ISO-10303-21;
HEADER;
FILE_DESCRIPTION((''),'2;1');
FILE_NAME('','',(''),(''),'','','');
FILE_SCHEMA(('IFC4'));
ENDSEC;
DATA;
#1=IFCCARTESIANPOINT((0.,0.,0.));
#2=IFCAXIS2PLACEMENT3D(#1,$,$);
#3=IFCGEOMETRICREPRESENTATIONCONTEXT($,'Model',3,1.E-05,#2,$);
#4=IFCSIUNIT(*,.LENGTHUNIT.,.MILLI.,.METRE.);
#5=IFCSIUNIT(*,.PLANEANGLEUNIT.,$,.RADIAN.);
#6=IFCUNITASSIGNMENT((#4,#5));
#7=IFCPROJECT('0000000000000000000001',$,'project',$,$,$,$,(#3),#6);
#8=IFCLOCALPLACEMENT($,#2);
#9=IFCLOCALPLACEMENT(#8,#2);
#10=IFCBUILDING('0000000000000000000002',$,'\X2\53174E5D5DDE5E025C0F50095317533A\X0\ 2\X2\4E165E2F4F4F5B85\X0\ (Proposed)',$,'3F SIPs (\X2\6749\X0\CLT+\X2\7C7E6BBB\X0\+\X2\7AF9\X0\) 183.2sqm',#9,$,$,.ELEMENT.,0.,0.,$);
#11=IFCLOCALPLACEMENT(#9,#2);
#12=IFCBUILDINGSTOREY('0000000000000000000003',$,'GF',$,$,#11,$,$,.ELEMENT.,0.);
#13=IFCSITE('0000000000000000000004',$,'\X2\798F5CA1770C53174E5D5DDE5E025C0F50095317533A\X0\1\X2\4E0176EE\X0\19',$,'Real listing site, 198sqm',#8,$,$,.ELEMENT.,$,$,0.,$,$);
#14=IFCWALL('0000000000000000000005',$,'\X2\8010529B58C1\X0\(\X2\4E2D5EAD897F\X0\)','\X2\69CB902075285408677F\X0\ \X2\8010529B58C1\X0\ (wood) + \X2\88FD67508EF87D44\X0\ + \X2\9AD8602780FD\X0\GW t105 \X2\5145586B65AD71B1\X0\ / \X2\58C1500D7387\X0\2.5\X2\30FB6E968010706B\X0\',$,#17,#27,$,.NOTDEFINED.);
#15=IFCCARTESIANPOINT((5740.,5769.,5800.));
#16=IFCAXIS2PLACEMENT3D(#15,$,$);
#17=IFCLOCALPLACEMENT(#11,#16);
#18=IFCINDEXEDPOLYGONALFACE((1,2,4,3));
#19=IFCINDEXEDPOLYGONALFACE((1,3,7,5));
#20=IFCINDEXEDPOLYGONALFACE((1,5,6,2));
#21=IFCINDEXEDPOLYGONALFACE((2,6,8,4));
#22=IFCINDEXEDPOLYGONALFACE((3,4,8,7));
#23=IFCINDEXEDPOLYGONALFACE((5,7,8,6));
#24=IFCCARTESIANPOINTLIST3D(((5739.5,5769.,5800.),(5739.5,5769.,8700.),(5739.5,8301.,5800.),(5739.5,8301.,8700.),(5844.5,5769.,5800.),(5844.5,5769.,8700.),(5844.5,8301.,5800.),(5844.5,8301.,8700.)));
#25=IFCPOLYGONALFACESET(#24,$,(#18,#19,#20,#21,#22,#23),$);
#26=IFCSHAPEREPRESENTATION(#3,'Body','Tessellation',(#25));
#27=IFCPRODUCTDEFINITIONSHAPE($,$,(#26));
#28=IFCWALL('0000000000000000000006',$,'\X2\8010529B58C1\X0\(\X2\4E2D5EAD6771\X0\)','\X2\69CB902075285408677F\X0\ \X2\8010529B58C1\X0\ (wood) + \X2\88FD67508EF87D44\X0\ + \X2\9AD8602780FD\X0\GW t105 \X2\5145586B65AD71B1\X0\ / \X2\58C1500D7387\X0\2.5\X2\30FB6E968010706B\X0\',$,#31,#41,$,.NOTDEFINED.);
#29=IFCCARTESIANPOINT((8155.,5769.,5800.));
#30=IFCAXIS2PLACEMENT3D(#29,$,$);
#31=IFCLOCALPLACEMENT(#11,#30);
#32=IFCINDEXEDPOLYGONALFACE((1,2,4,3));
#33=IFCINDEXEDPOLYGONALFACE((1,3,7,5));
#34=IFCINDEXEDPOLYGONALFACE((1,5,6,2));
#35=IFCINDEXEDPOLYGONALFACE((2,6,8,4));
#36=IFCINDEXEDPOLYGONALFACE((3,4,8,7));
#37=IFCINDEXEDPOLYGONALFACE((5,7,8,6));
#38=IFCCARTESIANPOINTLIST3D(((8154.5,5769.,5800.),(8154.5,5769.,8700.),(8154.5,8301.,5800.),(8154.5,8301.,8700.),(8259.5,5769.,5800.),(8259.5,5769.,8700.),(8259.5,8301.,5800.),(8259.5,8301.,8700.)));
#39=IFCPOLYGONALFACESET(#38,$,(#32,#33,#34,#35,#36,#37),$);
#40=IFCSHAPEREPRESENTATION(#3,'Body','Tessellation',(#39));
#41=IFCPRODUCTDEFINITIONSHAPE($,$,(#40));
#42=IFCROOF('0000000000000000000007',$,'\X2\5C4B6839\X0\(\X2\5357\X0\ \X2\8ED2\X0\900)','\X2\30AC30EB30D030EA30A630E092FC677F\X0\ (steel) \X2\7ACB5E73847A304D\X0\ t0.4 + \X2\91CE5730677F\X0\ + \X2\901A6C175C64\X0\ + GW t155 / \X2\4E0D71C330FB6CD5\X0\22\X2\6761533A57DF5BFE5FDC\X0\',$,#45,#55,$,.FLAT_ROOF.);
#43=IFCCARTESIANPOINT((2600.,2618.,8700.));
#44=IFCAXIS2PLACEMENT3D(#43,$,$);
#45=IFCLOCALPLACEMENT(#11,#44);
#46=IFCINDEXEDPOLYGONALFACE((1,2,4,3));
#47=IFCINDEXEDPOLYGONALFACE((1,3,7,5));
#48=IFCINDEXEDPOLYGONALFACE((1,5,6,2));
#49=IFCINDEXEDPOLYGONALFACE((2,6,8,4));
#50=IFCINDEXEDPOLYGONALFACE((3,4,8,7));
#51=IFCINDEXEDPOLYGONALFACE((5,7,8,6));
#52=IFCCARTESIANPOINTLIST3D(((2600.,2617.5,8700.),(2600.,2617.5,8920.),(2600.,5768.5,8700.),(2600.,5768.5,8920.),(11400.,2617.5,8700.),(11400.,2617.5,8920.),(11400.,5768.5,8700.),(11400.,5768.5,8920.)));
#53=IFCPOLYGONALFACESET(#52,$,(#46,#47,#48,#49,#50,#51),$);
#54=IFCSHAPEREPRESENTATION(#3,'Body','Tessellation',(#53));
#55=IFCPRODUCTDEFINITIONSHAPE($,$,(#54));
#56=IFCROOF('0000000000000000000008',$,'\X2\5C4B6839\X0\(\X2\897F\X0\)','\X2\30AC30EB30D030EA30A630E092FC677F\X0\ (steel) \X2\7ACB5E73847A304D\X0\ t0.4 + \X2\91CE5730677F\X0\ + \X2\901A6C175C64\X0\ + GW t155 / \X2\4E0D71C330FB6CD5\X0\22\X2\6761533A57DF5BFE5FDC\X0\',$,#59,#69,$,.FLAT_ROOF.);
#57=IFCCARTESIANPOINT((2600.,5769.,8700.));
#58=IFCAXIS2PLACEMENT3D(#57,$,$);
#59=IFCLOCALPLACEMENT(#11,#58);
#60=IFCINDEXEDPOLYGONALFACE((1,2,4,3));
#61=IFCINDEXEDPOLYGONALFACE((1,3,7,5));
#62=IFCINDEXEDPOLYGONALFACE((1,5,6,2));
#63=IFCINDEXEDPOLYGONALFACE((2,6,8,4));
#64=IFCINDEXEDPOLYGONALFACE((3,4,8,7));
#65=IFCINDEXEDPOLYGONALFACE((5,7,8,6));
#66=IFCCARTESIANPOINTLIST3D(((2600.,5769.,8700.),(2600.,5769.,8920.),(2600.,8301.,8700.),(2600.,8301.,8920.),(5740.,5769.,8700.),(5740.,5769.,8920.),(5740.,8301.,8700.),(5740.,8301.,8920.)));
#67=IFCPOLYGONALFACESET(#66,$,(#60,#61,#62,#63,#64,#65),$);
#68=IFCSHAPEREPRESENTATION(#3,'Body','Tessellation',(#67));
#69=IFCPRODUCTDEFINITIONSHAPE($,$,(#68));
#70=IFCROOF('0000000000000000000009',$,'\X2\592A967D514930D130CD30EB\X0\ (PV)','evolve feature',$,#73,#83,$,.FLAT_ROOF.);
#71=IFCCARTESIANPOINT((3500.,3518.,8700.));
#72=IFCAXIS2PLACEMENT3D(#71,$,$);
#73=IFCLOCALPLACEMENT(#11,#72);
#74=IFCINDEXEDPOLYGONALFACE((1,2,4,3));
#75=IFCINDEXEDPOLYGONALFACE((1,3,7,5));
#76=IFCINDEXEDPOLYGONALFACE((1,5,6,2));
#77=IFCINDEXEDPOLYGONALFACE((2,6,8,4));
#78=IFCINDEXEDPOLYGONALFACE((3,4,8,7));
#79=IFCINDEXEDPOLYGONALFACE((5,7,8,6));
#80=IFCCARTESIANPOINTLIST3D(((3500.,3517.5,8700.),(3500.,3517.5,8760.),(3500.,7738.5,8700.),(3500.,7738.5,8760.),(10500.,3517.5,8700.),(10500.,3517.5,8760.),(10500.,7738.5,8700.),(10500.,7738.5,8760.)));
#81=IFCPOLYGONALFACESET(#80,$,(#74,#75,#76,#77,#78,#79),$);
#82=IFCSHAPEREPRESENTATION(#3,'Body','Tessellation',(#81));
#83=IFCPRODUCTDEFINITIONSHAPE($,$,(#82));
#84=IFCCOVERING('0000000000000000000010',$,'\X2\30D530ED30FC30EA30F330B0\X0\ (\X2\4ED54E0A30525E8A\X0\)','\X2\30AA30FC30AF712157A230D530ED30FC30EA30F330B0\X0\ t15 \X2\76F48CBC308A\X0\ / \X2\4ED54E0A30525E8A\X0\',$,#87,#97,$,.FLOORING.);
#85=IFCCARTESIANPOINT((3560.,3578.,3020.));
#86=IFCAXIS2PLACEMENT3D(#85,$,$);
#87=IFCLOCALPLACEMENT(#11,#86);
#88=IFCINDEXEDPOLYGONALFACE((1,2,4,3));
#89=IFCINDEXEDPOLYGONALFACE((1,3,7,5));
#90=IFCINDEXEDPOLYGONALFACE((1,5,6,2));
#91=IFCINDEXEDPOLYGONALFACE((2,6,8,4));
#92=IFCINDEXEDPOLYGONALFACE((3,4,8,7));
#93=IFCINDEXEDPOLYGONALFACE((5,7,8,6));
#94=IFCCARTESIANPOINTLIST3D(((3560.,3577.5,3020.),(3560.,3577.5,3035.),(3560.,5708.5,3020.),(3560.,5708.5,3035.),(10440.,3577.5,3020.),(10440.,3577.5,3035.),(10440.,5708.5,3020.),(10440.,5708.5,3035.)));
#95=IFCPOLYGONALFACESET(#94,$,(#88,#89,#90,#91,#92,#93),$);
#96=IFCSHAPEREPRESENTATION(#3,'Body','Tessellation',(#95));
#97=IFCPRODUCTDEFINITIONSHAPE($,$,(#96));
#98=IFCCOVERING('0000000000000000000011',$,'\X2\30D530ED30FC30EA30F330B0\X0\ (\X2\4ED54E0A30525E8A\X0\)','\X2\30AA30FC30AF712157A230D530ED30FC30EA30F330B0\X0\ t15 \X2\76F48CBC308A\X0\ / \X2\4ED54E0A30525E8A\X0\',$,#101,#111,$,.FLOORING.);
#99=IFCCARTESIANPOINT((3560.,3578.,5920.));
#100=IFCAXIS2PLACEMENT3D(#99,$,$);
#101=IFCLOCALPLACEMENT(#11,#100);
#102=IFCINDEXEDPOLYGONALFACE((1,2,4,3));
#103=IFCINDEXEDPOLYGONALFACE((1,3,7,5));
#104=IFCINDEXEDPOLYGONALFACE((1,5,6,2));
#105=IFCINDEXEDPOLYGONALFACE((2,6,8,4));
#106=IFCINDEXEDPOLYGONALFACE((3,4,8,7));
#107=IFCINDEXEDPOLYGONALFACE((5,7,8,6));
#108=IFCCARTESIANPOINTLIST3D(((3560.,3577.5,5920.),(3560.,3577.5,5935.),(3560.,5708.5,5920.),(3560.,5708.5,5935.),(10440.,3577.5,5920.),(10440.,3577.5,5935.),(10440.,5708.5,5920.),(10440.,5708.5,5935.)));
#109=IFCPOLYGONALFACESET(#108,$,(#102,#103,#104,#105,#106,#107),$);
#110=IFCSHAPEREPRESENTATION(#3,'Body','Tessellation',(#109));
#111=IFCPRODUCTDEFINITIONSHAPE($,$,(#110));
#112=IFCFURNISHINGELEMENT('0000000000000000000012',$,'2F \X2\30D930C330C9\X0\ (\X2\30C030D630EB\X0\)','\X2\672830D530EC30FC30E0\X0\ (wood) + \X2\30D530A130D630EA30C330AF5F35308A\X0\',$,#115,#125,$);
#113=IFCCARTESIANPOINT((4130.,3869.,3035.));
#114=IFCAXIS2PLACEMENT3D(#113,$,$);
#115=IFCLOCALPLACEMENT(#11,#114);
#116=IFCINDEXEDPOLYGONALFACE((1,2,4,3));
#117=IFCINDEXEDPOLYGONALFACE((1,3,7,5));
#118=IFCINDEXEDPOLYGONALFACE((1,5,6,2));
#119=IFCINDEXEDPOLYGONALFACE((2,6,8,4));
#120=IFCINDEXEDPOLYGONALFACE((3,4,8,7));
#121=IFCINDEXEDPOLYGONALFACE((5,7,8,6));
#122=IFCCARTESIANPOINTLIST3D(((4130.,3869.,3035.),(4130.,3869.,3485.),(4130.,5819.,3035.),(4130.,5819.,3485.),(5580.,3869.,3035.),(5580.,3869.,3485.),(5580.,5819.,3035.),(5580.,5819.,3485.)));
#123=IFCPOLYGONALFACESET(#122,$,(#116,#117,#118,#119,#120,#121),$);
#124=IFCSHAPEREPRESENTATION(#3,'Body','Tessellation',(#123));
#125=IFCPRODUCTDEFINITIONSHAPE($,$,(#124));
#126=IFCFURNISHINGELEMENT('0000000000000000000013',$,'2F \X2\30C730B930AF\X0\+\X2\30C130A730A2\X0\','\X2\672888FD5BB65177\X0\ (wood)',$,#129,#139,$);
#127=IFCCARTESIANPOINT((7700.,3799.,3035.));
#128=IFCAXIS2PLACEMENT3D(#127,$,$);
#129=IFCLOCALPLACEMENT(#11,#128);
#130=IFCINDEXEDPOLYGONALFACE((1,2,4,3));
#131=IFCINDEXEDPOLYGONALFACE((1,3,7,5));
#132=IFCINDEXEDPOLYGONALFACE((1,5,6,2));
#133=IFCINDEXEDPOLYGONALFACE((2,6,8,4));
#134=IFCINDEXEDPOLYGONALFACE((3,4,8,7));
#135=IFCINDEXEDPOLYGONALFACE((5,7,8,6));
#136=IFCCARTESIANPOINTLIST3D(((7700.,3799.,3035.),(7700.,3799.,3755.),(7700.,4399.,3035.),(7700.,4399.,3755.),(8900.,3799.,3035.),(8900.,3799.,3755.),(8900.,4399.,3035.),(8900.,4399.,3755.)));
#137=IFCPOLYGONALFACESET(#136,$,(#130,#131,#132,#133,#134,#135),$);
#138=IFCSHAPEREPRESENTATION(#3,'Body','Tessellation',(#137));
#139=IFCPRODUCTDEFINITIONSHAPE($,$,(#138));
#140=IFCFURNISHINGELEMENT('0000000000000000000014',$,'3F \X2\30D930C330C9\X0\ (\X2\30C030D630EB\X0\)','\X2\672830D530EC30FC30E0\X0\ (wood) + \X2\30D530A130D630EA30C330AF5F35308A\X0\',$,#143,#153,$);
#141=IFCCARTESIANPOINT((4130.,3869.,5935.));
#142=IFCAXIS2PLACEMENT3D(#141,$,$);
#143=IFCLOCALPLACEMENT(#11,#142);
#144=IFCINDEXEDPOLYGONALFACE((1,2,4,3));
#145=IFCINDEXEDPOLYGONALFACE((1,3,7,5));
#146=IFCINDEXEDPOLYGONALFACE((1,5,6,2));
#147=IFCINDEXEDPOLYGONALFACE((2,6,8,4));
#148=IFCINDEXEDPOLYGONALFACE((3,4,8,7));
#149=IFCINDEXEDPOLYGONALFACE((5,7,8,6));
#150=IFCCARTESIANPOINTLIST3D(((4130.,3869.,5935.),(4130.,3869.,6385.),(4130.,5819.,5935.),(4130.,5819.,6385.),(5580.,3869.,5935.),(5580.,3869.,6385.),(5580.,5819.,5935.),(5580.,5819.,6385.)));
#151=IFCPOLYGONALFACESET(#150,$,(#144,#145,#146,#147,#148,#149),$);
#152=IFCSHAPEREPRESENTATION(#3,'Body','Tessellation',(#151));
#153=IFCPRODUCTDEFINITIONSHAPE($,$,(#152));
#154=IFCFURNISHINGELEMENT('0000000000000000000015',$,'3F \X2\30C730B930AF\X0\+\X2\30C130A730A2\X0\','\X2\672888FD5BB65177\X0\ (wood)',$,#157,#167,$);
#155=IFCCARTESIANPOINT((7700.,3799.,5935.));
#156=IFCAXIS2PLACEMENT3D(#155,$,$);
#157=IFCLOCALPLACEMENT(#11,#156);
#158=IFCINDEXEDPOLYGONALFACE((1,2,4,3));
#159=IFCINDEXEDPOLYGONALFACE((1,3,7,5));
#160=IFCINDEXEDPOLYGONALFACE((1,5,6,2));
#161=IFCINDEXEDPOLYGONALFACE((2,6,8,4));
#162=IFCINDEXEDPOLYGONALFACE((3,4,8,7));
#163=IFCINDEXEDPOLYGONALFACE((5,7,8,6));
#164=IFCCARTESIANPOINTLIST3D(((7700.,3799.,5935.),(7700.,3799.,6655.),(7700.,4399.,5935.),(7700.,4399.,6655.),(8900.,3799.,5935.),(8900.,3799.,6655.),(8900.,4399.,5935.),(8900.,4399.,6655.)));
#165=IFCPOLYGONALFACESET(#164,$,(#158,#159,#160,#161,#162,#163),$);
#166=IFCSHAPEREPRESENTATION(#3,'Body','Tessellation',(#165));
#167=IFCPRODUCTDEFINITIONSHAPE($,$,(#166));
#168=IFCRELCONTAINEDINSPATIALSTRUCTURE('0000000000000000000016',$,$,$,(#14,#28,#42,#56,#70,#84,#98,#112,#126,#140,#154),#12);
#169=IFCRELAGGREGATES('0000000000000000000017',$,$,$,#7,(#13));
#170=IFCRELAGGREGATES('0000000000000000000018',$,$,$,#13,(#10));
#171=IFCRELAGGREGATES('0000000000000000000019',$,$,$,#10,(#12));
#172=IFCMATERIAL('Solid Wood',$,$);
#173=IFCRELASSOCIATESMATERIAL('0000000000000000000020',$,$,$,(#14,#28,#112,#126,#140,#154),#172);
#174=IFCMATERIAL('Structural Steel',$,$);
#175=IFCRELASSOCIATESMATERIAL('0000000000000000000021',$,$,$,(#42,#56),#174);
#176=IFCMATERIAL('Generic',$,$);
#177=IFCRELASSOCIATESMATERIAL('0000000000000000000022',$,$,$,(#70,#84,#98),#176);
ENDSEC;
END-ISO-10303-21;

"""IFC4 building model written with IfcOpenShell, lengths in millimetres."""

from ifc_helpers import new_model, si_unit, frame, frame_2d, origin, place, context, project, spatial, rectangle, extrude, material, element, save


model = new_model("IFC4")

# Units and contexts
model_context = context("Model", 3, precision=1e-05, world=origin())
ifc_project = project(units=[si_unit("LENGTHUNIT", "METRE", prefix="MILLI"), si_unit("PLANEANGLEUNIT", "RADIAN")], contexts=[model_context])

# Site, building, storey
site_placement = place(None, origin())
site = spatial("IfcSite", under=ifc_project, at=site_placement, Name="福岡県北九州市小倉北区1丁目19", ObjectType="Real listing site, 198sqm", CompositionType="ELEMENT", RefElevation=0.0)
building_placement = place(site_placement, origin())
building = spatial("IfcBuilding", under=site, at=building_placement, Name="北九州市小倉北区 2世帯住宅 (Proposed)", ObjectType="3F SIPs (杉CLT+籾殻+竹) 183.2sqm", CompositionType="ELEMENT", ElevationOfRefHeight=0.0, ElevationOfTerrain=0.0)
storey_placement = place(building_placement, origin())
storey = spatial("IfcBuildingStorey", under=building, at=storey_placement, Name="GF", CompositionType="ELEMENT", Elevation=0.0)

# Shared definitions
ifc_material_1 = material(Name="Solid Wood")

# Walls
wall_1_placement = place(storey_placement, frame((5740.0, 5769.0, 5800.0)))
element("IfcWall", 1, at=wall_1_placement, inside=storey, material=ifc_material_1, Name="耐力壁(中庭西)", Description="構造用合板 耐力壁 (wood) + 製材軸組 + 高性能GW t105 充填断熱 / 壁倍率2.5・準耐火", PredefinedType="NOTDEFINED", context=model_context, shape_type="SweptSolid", body=[
    extrude(rectangle(XDim=105.0, YDim=2532.0, at=frame_2d((52.0, 1266.0))), frame((5740.0, 5769.0, 5800.0)), (0.0, 0.0, 1.0), 2900.0),
])
wall_2_placement = place(storey_placement, frame((8155.0, 5769.0, 5800.0)))
element("IfcWall", 2, at=wall_2_placement, inside=storey, material=ifc_material_1, Name="耐力壁(中庭東)", Description="構造用合板 耐力壁 (wood) + 製材軸組 + 高性能GW t105 充填断熱 / 壁倍率2.5・準耐火", PredefinedType="NOTDEFINED", context=model_context, shape_type="SweptSolid", body=[
    extrude(rectangle(XDim=105.0, YDim=2532.0, at=frame_2d((52.0, 1266.0))), frame((8155.0, 5769.0, 5800.0)), (0.0, 0.0, 1.0), 2900.0),
])

# Roofs
ifc_material_2 = material(Name="Structural Steel")
roof_1_placement = place(storey_placement, frame((2600.0, 2618.0, 8700.0)))
element("IfcRoof", 3, at=roof_1_placement, inside=storey, material=ifc_material_2, Name="屋根(南 軒900)", Description="ガルバリウム鋼板 (steel) 立平葺き t0.4 + 野地板 + 通気層 + GW t155 / 不燃・法22条区域対応", PredefinedType="FLAT_ROOF", context=model_context, shape_type="SweptSolid", body=[
    extrude(rectangle(XDim=8800.0, YDim=3151.0, at=frame_2d((4400.0, 1575.0))), frame((2600.0, 2618.0, 8700.0)), (0.0, 0.0, 1.0), 220.0),
])
roof_2_placement = place(storey_placement, frame((2600.0, 5769.0, 8700.0)))
element("IfcRoof", 4, at=roof_2_placement, inside=storey, material=ifc_material_2, Name="屋根(西)", Description="ガルバリウム鋼板 (steel) 立平葺き t0.4 + 野地板 + 通気層 + GW t155 / 不燃・法22条区域対応", PredefinedType="FLAT_ROOF", context=model_context, shape_type="SweptSolid", body=[
    extrude(rectangle(XDim=3140.0, YDim=2532.0, at=frame_2d((1570.0, 1266.0))), frame((2600.0, 5769.0, 8700.0)), (0.0, 0.0, 1.0), 220.0),
])
ifc_material_3 = material(Name="Generic")
roof_3_placement = place(storey_placement, frame((3500.0, 3518.0, 8700.0)))
element("IfcRoof", 5, at=roof_3_placement, inside=storey, material=ifc_material_3, Name="太陽光パネル (PV)", Description="evolve feature", PredefinedType="FLAT_ROOF", context=model_context, shape_type="SweptSolid", body=[
    extrude(rectangle(XDim=7000.0, YDim=4221.0, at=frame_2d((3500.0, 2110.0))), frame((3500.0, 3518.0, 8700.0)), (0.0, 0.0, 1.0), 60.0),
])

# Coverings
covering_1_placement = place(storey_placement, frame((3560.0, 3578.0, 3020.0)))
element("IfcCovering", 6, at=covering_1_placement, inside=storey, material=ifc_material_3, Name="フローリング (仕上げ床)", Description="オーク無垢フローリング t15 直貼り / 仕上げ床", PredefinedType="FLOORING", context=model_context, shape_type="SweptSolid", body=[
    extrude(rectangle(XDim=6880.0, YDim=2131.0, at=frame_2d((3440.0, 1065.0))), frame((3560.0, 3578.0, 3020.0)), (0.0, 0.0, 1.0), 15.0),
])
covering_2_placement = place(storey_placement, frame((3560.0, 3578.0, 5920.0)))
element("IfcCovering", 7, at=covering_2_placement, inside=storey, material=ifc_material_3, Name="フローリング (仕上げ床)", Description="オーク無垢フローリング t15 直貼り / 仕上げ床", PredefinedType="FLOORING", context=model_context, shape_type="SweptSolid", body=[
    extrude(rectangle(XDim=6880.0, YDim=2131.0, at=frame_2d((3440.0, 1065.0))), frame((3560.0, 3578.0, 5920.0)), (0.0, 0.0, 1.0), 15.0),
])

# Furnishing elements
furnishing_1_placement = place(storey_placement, frame((4130.0, 3869.0, 3035.0)))
element("IfcFurnishingElement", 8, at=furnishing_1_placement, inside=storey, material=ifc_material_1, Name="2F ベッド (ダブル)", Description="木フレーム (wood) + ファブリック張り", context=model_context, shape_type="SweptSolid", body=[
    extrude(rectangle(XDim=1450.0, YDim=1950.0, at=frame_2d((725.0, 975.0))), frame((4130.0, 3869.0, 3035.0)), (0.0, 0.0, 1.0), 450.0),
])
furnishing_2_placement = place(storey_placement, frame((7700.0, 3799.0, 3035.0)))
element("IfcFurnishingElement", 9, at=furnishing_2_placement, inside=storey, material=ifc_material_1, Name="2F デスク+チェア", Description="木製家具 (wood)", context=model_context, shape_type="SweptSolid", body=[
    extrude(rectangle(XDim=1200.0, YDim=600.0, at=frame_2d((600.0, 300.0))), frame((7700.0, 3799.0, 3035.0)), (0.0, 0.0, 1.0), 720.0),
])
furnishing_3_placement = place(storey_placement, frame((4130.0, 3869.0, 5935.0)))
element("IfcFurnishingElement", 10, at=furnishing_3_placement, inside=storey, material=ifc_material_1, Name="3F ベッド (ダブル)", Description="木フレーム (wood) + ファブリック張り", context=model_context, shape_type="SweptSolid", body=[
    extrude(rectangle(XDim=1450.0, YDim=1950.0, at=frame_2d((725.0, 975.0))), frame((4130.0, 3869.0, 5935.0)), (0.0, 0.0, 1.0), 450.0),
])
furnishing_4_placement = place(storey_placement, frame((7700.0, 3799.0, 5935.0)))
element("IfcFurnishingElement", 11, at=furnishing_4_placement, inside=storey, material=ifc_material_1, Name="3F デスク+チェア", Description="木製家具 (wood)", context=model_context, shape_type="SweptSolid", body=[
    extrude(rectangle(XDim=1200.0, YDim=600.0, at=frame_2d((600.0, 300.0))), frame((7700.0, 3799.0, 5935.0)), (0.0, 0.0, 1.0), 720.0),
])

save(model, "model.ifc")
